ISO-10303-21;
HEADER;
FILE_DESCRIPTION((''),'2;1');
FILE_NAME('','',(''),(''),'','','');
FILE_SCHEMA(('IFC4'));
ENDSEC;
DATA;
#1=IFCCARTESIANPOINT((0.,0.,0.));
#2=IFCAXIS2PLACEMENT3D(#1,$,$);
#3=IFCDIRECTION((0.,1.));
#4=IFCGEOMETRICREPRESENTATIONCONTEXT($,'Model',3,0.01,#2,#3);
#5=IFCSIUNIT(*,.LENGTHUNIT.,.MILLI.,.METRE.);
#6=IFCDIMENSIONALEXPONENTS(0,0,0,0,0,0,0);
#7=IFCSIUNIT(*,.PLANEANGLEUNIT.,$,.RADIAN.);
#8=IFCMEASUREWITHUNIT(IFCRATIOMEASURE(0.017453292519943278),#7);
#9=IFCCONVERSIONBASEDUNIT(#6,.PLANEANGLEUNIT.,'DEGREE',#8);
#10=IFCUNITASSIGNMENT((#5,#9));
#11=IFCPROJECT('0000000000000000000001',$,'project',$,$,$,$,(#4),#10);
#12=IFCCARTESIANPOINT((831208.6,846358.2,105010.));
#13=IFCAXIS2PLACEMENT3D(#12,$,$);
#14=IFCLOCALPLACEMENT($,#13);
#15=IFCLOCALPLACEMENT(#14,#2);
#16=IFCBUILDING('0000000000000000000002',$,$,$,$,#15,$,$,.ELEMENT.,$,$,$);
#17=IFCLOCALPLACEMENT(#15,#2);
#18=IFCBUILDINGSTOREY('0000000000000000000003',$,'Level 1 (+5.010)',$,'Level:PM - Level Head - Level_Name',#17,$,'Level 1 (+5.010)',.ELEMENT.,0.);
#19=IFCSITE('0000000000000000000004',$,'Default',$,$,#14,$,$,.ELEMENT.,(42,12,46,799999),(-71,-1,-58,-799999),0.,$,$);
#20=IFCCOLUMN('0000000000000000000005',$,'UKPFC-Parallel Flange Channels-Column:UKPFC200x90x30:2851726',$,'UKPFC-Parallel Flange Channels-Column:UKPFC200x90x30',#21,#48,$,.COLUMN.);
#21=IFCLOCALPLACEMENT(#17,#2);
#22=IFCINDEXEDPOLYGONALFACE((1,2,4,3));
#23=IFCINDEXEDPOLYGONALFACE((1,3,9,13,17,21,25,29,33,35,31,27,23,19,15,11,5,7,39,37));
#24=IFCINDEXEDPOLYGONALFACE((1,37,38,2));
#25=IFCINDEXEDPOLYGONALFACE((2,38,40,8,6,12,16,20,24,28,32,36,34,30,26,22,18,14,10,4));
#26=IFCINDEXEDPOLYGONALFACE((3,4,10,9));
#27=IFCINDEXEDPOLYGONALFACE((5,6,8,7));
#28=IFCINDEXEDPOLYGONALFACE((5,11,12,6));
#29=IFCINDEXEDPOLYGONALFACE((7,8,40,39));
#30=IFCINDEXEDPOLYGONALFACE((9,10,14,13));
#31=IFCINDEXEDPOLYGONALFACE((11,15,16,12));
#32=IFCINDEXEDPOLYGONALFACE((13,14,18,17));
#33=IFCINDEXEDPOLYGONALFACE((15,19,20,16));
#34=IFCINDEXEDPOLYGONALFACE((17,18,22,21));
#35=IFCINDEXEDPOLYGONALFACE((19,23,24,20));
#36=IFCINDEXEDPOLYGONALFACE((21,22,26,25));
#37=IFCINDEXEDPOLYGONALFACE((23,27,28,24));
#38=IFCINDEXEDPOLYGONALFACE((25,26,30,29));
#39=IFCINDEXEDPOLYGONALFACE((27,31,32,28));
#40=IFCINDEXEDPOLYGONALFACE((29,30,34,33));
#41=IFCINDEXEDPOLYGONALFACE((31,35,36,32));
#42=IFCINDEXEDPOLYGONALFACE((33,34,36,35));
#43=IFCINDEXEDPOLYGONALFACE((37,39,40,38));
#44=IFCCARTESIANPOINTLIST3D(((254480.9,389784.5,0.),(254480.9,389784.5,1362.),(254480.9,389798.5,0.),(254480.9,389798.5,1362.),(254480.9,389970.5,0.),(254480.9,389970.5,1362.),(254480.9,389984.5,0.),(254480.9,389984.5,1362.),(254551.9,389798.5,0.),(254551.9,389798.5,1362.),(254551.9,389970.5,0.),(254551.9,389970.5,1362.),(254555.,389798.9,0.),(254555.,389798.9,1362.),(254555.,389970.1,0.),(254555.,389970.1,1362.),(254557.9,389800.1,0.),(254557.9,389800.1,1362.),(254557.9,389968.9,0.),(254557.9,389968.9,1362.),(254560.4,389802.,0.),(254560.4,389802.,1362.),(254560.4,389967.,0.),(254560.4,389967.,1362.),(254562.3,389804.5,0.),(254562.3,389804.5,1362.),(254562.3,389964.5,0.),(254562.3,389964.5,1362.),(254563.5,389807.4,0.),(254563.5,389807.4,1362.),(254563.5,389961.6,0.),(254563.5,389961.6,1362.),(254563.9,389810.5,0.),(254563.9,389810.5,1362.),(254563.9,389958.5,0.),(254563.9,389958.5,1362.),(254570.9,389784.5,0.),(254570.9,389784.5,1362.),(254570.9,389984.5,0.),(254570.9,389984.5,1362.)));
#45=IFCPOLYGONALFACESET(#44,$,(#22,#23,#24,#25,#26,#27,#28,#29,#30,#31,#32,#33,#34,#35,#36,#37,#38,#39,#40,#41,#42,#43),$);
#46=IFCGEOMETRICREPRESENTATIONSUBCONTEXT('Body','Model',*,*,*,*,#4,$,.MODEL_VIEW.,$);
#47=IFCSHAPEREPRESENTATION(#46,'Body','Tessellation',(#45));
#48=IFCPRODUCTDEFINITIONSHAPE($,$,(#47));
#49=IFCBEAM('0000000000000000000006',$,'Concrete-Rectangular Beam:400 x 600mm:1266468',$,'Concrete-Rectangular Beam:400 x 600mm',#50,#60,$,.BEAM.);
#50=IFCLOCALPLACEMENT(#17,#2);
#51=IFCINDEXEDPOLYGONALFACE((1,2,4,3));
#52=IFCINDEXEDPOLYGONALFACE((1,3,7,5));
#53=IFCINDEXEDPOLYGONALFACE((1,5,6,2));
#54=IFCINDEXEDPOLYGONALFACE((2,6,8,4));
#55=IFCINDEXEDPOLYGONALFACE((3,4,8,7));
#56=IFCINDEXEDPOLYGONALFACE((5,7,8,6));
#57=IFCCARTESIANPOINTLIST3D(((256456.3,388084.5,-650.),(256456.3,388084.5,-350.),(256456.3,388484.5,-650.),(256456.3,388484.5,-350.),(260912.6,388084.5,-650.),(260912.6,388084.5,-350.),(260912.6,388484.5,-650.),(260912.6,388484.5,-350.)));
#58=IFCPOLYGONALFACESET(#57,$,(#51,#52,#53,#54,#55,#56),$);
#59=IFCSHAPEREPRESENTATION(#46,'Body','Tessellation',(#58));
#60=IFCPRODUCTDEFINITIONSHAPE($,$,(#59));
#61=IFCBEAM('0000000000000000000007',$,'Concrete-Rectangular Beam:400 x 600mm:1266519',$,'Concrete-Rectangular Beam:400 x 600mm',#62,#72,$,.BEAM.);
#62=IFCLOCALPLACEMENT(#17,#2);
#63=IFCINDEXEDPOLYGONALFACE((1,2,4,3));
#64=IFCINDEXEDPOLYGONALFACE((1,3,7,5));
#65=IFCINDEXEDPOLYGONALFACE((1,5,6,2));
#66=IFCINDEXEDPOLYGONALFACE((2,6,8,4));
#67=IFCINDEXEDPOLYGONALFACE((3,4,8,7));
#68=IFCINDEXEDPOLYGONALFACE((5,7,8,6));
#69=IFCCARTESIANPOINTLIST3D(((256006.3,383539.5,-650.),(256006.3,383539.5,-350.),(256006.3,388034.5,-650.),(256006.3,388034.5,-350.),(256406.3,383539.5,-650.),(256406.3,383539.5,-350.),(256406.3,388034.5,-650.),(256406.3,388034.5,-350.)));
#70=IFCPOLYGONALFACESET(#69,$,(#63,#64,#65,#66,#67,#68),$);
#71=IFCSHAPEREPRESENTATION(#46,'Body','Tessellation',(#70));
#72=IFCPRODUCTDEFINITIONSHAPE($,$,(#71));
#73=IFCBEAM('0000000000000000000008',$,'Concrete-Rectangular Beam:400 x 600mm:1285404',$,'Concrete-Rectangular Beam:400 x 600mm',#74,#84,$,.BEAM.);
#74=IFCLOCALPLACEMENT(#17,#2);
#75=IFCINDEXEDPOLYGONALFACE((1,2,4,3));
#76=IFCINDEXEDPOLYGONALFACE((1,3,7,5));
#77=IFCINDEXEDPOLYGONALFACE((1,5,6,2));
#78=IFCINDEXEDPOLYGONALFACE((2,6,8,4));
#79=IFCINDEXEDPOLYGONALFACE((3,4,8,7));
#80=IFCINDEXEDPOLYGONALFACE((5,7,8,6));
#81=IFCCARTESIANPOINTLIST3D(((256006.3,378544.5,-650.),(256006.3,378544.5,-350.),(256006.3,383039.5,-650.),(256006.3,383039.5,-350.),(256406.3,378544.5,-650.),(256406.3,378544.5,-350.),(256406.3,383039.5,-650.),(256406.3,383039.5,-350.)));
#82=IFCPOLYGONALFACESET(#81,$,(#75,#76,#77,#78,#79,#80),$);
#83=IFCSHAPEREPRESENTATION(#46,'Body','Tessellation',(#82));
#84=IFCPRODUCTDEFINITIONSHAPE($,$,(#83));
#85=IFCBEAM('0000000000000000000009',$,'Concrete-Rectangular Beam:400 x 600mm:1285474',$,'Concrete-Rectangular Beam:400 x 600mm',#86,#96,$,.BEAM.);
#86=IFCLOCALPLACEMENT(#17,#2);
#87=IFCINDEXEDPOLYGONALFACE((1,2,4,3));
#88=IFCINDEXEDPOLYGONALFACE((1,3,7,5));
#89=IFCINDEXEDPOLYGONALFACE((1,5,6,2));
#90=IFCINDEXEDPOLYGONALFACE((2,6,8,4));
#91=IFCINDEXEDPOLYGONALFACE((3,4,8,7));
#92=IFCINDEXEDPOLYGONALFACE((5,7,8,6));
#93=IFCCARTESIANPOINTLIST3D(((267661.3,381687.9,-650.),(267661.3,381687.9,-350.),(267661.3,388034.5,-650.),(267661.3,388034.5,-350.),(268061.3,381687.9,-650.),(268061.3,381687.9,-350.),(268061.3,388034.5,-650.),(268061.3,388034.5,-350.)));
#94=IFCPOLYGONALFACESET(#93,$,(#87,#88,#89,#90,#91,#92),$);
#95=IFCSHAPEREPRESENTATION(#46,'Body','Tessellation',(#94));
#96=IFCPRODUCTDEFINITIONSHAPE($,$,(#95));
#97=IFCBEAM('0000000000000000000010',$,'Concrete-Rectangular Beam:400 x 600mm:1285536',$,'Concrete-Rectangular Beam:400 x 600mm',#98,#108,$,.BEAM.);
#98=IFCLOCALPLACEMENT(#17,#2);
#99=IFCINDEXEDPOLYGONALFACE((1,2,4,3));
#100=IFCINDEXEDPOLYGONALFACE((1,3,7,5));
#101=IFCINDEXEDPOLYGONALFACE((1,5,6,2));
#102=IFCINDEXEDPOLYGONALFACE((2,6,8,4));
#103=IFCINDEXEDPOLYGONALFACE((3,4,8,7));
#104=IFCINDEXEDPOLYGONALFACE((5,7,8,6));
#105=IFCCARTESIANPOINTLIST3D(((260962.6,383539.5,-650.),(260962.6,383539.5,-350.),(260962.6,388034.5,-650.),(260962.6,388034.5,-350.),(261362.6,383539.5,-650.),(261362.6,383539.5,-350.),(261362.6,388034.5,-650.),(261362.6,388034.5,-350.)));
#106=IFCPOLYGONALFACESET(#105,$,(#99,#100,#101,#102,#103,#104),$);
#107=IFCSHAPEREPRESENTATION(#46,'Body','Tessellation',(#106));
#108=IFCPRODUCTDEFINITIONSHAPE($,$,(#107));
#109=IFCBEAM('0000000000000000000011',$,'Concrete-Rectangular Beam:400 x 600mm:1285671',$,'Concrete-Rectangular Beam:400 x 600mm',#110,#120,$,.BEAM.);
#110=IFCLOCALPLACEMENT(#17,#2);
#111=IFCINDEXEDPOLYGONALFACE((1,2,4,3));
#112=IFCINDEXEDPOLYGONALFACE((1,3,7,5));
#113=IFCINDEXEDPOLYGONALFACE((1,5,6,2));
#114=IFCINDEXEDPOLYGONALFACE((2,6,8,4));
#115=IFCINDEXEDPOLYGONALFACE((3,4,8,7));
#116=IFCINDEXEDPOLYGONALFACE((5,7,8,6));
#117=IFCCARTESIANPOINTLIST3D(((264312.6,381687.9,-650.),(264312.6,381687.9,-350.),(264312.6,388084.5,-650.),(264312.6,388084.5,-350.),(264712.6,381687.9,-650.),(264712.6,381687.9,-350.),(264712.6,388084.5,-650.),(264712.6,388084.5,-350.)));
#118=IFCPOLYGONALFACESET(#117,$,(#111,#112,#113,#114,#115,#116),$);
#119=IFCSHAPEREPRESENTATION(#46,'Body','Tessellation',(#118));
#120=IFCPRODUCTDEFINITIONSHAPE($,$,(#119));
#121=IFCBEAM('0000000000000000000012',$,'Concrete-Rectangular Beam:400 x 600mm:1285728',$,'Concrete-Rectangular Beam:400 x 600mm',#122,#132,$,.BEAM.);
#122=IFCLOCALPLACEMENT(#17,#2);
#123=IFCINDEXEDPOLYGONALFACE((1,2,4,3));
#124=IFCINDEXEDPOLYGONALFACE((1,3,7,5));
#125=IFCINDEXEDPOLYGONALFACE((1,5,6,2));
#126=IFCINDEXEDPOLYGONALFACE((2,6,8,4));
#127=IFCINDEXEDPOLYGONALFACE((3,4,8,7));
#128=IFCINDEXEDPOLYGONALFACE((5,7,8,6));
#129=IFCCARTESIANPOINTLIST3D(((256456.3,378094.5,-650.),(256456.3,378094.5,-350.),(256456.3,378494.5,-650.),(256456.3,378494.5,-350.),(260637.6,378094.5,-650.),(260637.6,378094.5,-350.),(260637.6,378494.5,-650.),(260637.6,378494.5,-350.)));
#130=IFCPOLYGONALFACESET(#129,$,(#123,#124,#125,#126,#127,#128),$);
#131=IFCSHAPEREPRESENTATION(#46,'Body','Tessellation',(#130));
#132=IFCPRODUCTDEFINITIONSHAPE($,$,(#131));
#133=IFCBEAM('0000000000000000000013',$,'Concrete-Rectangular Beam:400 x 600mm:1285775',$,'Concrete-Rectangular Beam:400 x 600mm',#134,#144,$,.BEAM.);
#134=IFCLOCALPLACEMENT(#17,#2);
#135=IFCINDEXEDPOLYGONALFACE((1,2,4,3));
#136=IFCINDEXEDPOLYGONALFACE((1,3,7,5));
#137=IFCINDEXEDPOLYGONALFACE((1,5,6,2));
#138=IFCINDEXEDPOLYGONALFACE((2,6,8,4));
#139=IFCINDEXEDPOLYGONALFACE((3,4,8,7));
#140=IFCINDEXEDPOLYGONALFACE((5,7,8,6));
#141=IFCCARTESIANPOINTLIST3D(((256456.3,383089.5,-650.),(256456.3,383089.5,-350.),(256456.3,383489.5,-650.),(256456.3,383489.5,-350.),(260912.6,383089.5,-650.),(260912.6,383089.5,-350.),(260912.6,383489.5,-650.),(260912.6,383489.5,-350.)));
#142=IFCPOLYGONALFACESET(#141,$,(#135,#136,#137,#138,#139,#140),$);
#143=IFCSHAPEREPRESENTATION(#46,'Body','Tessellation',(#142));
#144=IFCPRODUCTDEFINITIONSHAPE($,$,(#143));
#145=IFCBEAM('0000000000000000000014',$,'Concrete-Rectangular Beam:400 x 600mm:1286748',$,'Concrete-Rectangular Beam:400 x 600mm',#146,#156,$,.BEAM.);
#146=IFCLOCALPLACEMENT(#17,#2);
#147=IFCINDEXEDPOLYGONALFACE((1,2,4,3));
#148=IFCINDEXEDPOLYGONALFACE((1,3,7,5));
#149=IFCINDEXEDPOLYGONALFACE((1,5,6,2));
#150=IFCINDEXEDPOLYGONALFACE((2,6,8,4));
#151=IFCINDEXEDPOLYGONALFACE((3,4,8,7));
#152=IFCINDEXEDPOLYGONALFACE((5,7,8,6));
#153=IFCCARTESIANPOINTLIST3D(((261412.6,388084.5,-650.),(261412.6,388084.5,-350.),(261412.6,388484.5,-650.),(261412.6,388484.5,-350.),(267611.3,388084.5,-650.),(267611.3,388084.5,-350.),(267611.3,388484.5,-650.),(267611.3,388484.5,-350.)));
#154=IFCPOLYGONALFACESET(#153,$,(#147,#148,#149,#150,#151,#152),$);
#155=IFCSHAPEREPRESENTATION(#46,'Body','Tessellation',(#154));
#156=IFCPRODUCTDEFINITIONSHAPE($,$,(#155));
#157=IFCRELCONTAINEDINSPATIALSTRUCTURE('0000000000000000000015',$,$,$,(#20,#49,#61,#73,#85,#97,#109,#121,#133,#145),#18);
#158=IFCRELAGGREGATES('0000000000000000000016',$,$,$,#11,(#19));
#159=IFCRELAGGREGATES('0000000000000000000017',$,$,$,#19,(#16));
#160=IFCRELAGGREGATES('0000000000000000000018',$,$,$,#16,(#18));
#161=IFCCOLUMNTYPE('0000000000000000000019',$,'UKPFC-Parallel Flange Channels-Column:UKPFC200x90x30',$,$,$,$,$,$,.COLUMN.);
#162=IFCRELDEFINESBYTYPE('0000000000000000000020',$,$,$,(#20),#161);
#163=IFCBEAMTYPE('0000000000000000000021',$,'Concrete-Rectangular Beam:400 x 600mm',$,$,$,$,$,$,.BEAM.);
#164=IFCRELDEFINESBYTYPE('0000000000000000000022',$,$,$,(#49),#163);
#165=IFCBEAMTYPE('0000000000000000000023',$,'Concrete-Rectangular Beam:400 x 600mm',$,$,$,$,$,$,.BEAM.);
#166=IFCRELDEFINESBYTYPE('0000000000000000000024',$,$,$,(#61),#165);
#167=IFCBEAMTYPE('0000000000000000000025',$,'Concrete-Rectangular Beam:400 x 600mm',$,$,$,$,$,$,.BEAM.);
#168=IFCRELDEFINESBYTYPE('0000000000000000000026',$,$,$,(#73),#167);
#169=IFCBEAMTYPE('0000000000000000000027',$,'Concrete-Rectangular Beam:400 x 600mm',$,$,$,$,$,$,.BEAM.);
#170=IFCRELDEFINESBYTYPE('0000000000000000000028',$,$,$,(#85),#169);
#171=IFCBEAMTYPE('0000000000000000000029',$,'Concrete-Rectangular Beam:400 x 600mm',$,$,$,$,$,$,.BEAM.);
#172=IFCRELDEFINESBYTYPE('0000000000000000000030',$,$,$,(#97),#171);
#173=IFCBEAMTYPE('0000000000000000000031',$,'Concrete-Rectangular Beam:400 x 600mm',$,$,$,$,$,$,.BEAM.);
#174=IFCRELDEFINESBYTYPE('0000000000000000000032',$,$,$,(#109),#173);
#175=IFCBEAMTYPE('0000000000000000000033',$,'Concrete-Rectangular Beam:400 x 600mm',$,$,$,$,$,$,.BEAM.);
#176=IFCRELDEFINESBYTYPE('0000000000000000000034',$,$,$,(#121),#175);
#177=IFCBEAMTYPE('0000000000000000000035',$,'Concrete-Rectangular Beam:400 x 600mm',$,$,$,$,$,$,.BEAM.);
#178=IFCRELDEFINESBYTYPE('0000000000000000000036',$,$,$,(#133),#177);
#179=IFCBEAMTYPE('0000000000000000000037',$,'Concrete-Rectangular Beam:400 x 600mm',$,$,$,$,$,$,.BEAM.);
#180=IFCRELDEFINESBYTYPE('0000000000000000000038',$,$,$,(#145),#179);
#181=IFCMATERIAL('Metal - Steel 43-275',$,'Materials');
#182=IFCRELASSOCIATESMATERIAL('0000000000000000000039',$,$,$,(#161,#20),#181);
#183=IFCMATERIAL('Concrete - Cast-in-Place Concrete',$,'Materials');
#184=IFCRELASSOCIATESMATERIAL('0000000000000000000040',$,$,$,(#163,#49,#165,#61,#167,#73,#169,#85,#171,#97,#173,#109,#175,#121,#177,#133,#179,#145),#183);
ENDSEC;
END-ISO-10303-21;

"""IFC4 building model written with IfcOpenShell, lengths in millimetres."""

from ifc_helpers import new_model, entity, si_unit, converted_unit, direction, frame, origin, place, context, subcontext, project, spatial, line, arc, indexed_curve, outline, extrude, source, transform, mapped, material, type_object, type_shapes, element, save


model = new_model("IFC4")

# Units and contexts
model_context = context("Model", 3, precision=0.01, world=origin(), true_north=direction((0.0, 1.0)))
body_context = subcontext(model_context, "Body", "Model", "MODEL_VIEW")
ifc_project = project(units=[si_unit("LENGTHUNIT", "METRE", prefix="MILLI"), converted_unit("PLANEANGLEUNIT", "DEGREE", entity("IfcRatioMeasure", 0.017453292519943278), si_unit("PLANEANGLEUNIT", "RADIAN"), dimensions=[0, 0, 0, 0, 0, 0, 0])], contexts=[model_context])

# Site, building, storey
site_placement = place(None, frame((831208.6, 846358.2, 105010.0)))
site = spatial("IfcSite", under=ifc_project, at=site_placement, Name="Default", CompositionType="ELEMENT", RefLatitude=(42, 12, 46, 799999), RefLongitude=(-71, -1, -58, -799999), RefElevation=0.0)
building_placement = place(site_placement, origin())
building = spatial("IfcBuilding", under=site, at=building_placement, CompositionType="ELEMENT")
storey_placement = place(building_placement, origin())
storey = spatial("IfcBuildingStorey", under=building, at=storey_placement, Name="Level 1 (+5.010)", ObjectType="Level:PM - Level Head - Level_Name", LongName="Level 1 (+5.010)", CompositionType="ELEMENT", Elevation=0.0)

# Column
ifc_material_1 = material(Name="Concrete - Cast-in-Place Concrete", Category="Materials")
ifc_material_2 = material(Name="Metal - Steel 43-275", Category="Materials")
column_type_1 = type_object("IfcColumnType", Name="UKPFC-Parallel Flange Channels-Column:UKPFC200x90x30", PredefinedType="COLUMN", material=ifc_material_2)
shared_shape_1 = source(origin(), body_context, "Body", "SweptSolid", [
    extrude(outline(indexed_curve([(86.0, -48.8), (100.0, -48.8), (100.0, 41.2), (-100.0, 41.2), (-100.0, -48.8), (-86.0, -48.8), (-86.0, 22.2), (-82.5, 30.7), (-74.0, 34.2), (74.0, 34.2), (82.5, 30.7), (86.0, 22.2)], segments=[line(1, 2, 3, 4, 5, 6, 7), arc(7, 8, 9), line(9, 10), arc(10, 11, 12), line(12, 1)], self_intersect=False)), frame((254529.7, 389884.5, 0.0), z_axis=(0.0, 0.0, 1.0), x_axis=(0.0, -1.0, 0.0)), (0.0, 0.0, 1.0), 1362.0),
])
type_shapes(column_type_1, [shared_shape_1])
column_1_placement = place(storey_placement, origin())
element("IfcColumn", 1, at=column_1_placement, inside=storey, type_object=column_type_1, material=ifc_material_2, Name="UKPFC-Parallel Flange Channels-Column:UKPFC200x90x30:2851726", ObjectType="UKPFC-Parallel Flange Channels-Column:UKPFC200x90x30", PredefinedType="COLUMN", context=body_context, shape_type="MappedRepresentation", body=[
    mapped(shared_shape_1, transform((0.0, 0.0, 0.0), scale=1.0)),
])

# Beams
beam_type_1 = type_object("IfcBeamType", Name="Concrete-Rectangular Beam:400 x 600mm", PredefinedType="BEAM", material=ifc_material_1)
shared_shape_2 = source(origin(), body_context, "Body", "SweptSolid", [
    extrude(outline(indexed_curve([(-150.0, -200.0), (150.0, -200.0), (150.0, 200.0), (-150.0, 200.0), (-150.0, -200.0)], self_intersect=False)), frame((256456.3, 388284.5, -500.0), z_axis=(1.0, 0.0, 0.0), x_axis=(0.0, 0.0, -1.0)), (0.0, 0.0, 1.0), 4456.3),
])
type_shapes(beam_type_1, [shared_shape_2])
beam_1_placement = place(storey_placement, origin())
element("IfcBeam", 2, at=beam_1_placement, inside=storey, type_object=beam_type_1, material=ifc_material_1, Name="Concrete-Rectangular Beam:400 x 600mm:1266468", ObjectType="Concrete-Rectangular Beam:400 x 600mm", PredefinedType="BEAM", context=body_context, shape_type="MappedRepresentation", body=[
    mapped(shared_shape_2, transform((0.0, 0.0, 0.0), scale=1.0)),
])
beam_type_2 = type_object("IfcBeamType", Name="Concrete-Rectangular Beam:400 x 600mm", PredefinedType="BEAM", material=ifc_material_1)
shared_shape_3 = source(origin(), body_context, "Body", "SweptSolid", [
    extrude(outline(indexed_curve([(-200.0, -150.0), (200.0, -150.0), (200.0, 150.0), (-200.0, 150.0), (-200.0, -150.0)], self_intersect=False)), frame((256206.3, 383539.5, -500.0), z_axis=(0.0, 1.0, 0.0), x_axis=(-1.0, 0.0, 0.0)), (0.0, 0.0, 1.0), 4495.0),
])
type_shapes(beam_type_2, [shared_shape_3])
beam_2_placement = place(storey_placement, origin())
element("IfcBeam", 3, at=beam_2_placement, inside=storey, type_object=beam_type_2, material=ifc_material_1, Name="Concrete-Rectangular Beam:400 x 600mm:1266519", ObjectType="Concrete-Rectangular Beam:400 x 600mm", PredefinedType="BEAM", context=body_context, shape_type="MappedRepresentation", body=[
    mapped(shared_shape_3, transform((0.0, 0.0, 0.0), scale=1.0)),
])
beam_type_3 = type_object("IfcBeamType", Name="Concrete-Rectangular Beam:400 x 600mm", PredefinedType="BEAM", material=ifc_material_1)
shared_shape_4 = source(origin(), body_context, "Body", "SweptSolid", [
    extrude(outline(indexed_curve([(-200.0, -150.0), (200.0, -150.0), (200.0, 150.0), (-200.0, 150.0), (-200.0, -150.0)], self_intersect=False)), frame((256206.3, 378544.5, -500.0), z_axis=(0.0, 1.0, 0.0), x_axis=(-1.0, 0.0, 0.0)), (0.0, 0.0, 1.0), 4495.0),
])
type_shapes(beam_type_3, [shared_shape_4])
beam_3_placement = place(storey_placement, origin())
element("IfcBeam", 4, at=beam_3_placement, inside=storey, type_object=beam_type_3, material=ifc_material_1, Name="Concrete-Rectangular Beam:400 x 600mm:1285404", ObjectType="Concrete-Rectangular Beam:400 x 600mm", PredefinedType="BEAM", context=body_context, shape_type="MappedRepresentation", body=[
    mapped(shared_shape_4, transform((0.0, 0.0, 0.0), scale=1.0)),
])
beam_type_4 = type_object("IfcBeamType", Name="Concrete-Rectangular Beam:400 x 600mm", PredefinedType="BEAM", material=ifc_material_1)
shared_shape_5 = source(origin(), body_context, "Body", "SweptSolid", [
    extrude(outline(indexed_curve([(-200.0, -150.0), (200.0, -150.0), (200.0, 150.0), (-200.0, 150.0), (-200.0, -150.0)], self_intersect=False)), frame((267861.3, 388034.5, -500.0), z_axis=(0.0, -1.0, 0.0), x_axis=(-1.0, 0.0, 0.0)), (0.0, 0.0, 1.0), 6346.6),
])
type_shapes(beam_type_4, [shared_shape_5])
beam_4_placement = place(storey_placement, origin())
element("IfcBeam", 5, at=beam_4_placement, inside=storey, type_object=beam_type_4, material=ifc_material_1, Name="Concrete-Rectangular Beam:400 x 600mm:1285474", ObjectType="Concrete-Rectangular Beam:400 x 600mm", PredefinedType="BEAM", context=body_context, shape_type="MappedRepresentation", body=[
    mapped(shared_shape_5, transform((0.0, 0.0, 0.0), scale=1.0)),
])
beam_type_5 = type_object("IfcBeamType", Name="Concrete-Rectangular Beam:400 x 600mm", PredefinedType="BEAM", material=ifc_material_1)
shared_shape_6 = source(origin(), body_context, "Body", "SweptSolid", [
    extrude(outline(indexed_curve([(-200.0, -150.0), (200.0, -150.0), (200.0, 150.0), (-200.0, 150.0), (-200.0, -150.0)], self_intersect=False)), frame((261162.6, 388034.5, -500.0), z_axis=(0.0, -1.0, 0.0), x_axis=(-1.0, 0.0, 0.0)), (0.0, 0.0, 1.0), 4495.0),
])
type_shapes(beam_type_5, [shared_shape_6])
beam_5_placement = place(storey_placement, origin())
element("IfcBeam", 6, at=beam_5_placement, inside=storey, type_object=beam_type_5, material=ifc_material_1, Name="Concrete-Rectangular Beam:400 x 600mm:1285536", ObjectType="Concrete-Rectangular Beam:400 x 600mm", PredefinedType="BEAM", context=body_context, shape_type="MappedRepresentation", body=[
    mapped(shared_shape_6, transform((0.0, 0.0, 0.0), scale=1.0)),
])
beam_type_6 = type_object("IfcBeamType", Name="Concrete-Rectangular Beam:400 x 600mm", PredefinedType="BEAM", material=ifc_material_1)
shared_shape_7 = source(origin(), body_context, "Body", "SweptSolid", [
    extrude(outline(indexed_curve([(-200.0, -150.0), (200.0, -150.0), (200.0, 150.0), (-200.0, 150.0), (-200.0, -150.0)], self_intersect=False)), frame((264512.6, 388084.5, -500.0), z_axis=(0.0, -1.0, 0.0), x_axis=(-1.0, 0.0, 0.0)), (0.0, 0.0, 1.0), 6396.6),
])
type_shapes(beam_type_6, [shared_shape_7])
beam_6_placement = place(storey_placement, origin())
element("IfcBeam", 7, at=beam_6_placement, inside=storey, type_object=beam_type_6, material=ifc_material_1, Name="Concrete-Rectangular Beam:400 x 600mm:1285671", ObjectType="Concrete-Rectangular Beam:400 x 600mm", PredefinedType="BEAM", context=body_context, shape_type="MappedRepresentation", body=[
    mapped(shared_shape_7, transform((0.0, 0.0, 0.0), scale=1.0)),
])
beam_type_7 = type_object("IfcBeamType", Name="Concrete-Rectangular Beam:400 x 600mm", PredefinedType="BEAM", material=ifc_material_1)
shared_shape_8 = source(origin(), body_context, "Body", "SweptSolid", [
    extrude(outline(indexed_curve([(-150.0, -200.0), (150.0, -200.0), (150.0, 200.0), (-150.0, 200.0), (-150.0, -200.0)], self_intersect=False)), frame((256456.3, 378294.5, -500.0), z_axis=(1.0, 0.0, 0.0), x_axis=(0.0, 0.0, -1.0)), (0.0, 0.0, 1.0), 4181.3),
])
type_shapes(beam_type_7, [shared_shape_8])
beam_7_placement = place(storey_placement, origin())
element("IfcBeam", 8, at=beam_7_placement, inside=storey, type_object=beam_type_7, material=ifc_material_1, Name="Concrete-Rectangular Beam:400 x 600mm:1285728", ObjectType="Concrete-Rectangular Beam:400 x 600mm", PredefinedType="BEAM", context=body_context, shape_type="MappedRepresentation", body=[
    mapped(shared_shape_8, transform((0.0, 0.0, 0.0), scale=1.0)),
])
beam_type_8 = type_object("IfcBeamType", Name="Concrete-Rectangular Beam:400 x 600mm", PredefinedType="BEAM", material=ifc_material_1)
shared_shape_9 = source(origin(), body_context, "Body", "SweptSolid", [
    extrude(outline(indexed_curve([(-150.0, -200.0), (150.0, -200.0), (150.0, 200.0), (-150.0, 200.0), (-150.0, -200.0)], self_intersect=False)), frame((256456.3, 383289.5, -500.0), z_axis=(1.0, 0.0, 0.0), x_axis=(0.0, 0.0, -1.0)), (0.0, 0.0, 1.0), 4456.3),
])
type_shapes(beam_type_8, [shared_shape_9])
beam_8_placement = place(storey_placement, origin())
element("IfcBeam", 9, at=beam_8_placement, inside=storey, type_object=beam_type_8, material=ifc_material_1, Name="Concrete-Rectangular Beam:400 x 600mm:1285775", ObjectType="Concrete-Rectangular Beam:400 x 600mm", PredefinedType="BEAM", context=body_context, shape_type="MappedRepresentation", body=[
    mapped(shared_shape_9, transform((0.0, 0.0, 0.0), scale=1.0)),
])
beam_type_9 = type_object("IfcBeamType", Name="Concrete-Rectangular Beam:400 x 600mm", PredefinedType="BEAM", material=ifc_material_1)
shared_shape_10 = source(origin(), body_context, "Body", "SweptSolid", [
    extrude(outline(indexed_curve([(-150.0, -200.0), (150.0, -200.0), (150.0, 200.0), (-150.0, 200.0), (-150.0, -200.0)], self_intersect=False)), frame((261412.6, 388284.5, -500.0), z_axis=(1.0, 0.0, 0.0), x_axis=(0.0, 0.0, -1.0)), (0.0, 0.0, 1.0), 6198.7),
])
type_shapes(beam_type_9, [shared_shape_10])
beam_9_placement = place(storey_placement, origin())
element("IfcBeam", 10, at=beam_9_placement, inside=storey, type_object=beam_type_9, material=ifc_material_1, Name="Concrete-Rectangular Beam:400 x 600mm:1286748", ObjectType="Concrete-Rectangular Beam:400 x 600mm", PredefinedType="BEAM", context=body_context, shape_type="MappedRepresentation", body=[
    mapped(shared_shape_10, transform((0.0, 0.0, 0.0), scale=1.0)),
])

save(model, "model.ifc")
